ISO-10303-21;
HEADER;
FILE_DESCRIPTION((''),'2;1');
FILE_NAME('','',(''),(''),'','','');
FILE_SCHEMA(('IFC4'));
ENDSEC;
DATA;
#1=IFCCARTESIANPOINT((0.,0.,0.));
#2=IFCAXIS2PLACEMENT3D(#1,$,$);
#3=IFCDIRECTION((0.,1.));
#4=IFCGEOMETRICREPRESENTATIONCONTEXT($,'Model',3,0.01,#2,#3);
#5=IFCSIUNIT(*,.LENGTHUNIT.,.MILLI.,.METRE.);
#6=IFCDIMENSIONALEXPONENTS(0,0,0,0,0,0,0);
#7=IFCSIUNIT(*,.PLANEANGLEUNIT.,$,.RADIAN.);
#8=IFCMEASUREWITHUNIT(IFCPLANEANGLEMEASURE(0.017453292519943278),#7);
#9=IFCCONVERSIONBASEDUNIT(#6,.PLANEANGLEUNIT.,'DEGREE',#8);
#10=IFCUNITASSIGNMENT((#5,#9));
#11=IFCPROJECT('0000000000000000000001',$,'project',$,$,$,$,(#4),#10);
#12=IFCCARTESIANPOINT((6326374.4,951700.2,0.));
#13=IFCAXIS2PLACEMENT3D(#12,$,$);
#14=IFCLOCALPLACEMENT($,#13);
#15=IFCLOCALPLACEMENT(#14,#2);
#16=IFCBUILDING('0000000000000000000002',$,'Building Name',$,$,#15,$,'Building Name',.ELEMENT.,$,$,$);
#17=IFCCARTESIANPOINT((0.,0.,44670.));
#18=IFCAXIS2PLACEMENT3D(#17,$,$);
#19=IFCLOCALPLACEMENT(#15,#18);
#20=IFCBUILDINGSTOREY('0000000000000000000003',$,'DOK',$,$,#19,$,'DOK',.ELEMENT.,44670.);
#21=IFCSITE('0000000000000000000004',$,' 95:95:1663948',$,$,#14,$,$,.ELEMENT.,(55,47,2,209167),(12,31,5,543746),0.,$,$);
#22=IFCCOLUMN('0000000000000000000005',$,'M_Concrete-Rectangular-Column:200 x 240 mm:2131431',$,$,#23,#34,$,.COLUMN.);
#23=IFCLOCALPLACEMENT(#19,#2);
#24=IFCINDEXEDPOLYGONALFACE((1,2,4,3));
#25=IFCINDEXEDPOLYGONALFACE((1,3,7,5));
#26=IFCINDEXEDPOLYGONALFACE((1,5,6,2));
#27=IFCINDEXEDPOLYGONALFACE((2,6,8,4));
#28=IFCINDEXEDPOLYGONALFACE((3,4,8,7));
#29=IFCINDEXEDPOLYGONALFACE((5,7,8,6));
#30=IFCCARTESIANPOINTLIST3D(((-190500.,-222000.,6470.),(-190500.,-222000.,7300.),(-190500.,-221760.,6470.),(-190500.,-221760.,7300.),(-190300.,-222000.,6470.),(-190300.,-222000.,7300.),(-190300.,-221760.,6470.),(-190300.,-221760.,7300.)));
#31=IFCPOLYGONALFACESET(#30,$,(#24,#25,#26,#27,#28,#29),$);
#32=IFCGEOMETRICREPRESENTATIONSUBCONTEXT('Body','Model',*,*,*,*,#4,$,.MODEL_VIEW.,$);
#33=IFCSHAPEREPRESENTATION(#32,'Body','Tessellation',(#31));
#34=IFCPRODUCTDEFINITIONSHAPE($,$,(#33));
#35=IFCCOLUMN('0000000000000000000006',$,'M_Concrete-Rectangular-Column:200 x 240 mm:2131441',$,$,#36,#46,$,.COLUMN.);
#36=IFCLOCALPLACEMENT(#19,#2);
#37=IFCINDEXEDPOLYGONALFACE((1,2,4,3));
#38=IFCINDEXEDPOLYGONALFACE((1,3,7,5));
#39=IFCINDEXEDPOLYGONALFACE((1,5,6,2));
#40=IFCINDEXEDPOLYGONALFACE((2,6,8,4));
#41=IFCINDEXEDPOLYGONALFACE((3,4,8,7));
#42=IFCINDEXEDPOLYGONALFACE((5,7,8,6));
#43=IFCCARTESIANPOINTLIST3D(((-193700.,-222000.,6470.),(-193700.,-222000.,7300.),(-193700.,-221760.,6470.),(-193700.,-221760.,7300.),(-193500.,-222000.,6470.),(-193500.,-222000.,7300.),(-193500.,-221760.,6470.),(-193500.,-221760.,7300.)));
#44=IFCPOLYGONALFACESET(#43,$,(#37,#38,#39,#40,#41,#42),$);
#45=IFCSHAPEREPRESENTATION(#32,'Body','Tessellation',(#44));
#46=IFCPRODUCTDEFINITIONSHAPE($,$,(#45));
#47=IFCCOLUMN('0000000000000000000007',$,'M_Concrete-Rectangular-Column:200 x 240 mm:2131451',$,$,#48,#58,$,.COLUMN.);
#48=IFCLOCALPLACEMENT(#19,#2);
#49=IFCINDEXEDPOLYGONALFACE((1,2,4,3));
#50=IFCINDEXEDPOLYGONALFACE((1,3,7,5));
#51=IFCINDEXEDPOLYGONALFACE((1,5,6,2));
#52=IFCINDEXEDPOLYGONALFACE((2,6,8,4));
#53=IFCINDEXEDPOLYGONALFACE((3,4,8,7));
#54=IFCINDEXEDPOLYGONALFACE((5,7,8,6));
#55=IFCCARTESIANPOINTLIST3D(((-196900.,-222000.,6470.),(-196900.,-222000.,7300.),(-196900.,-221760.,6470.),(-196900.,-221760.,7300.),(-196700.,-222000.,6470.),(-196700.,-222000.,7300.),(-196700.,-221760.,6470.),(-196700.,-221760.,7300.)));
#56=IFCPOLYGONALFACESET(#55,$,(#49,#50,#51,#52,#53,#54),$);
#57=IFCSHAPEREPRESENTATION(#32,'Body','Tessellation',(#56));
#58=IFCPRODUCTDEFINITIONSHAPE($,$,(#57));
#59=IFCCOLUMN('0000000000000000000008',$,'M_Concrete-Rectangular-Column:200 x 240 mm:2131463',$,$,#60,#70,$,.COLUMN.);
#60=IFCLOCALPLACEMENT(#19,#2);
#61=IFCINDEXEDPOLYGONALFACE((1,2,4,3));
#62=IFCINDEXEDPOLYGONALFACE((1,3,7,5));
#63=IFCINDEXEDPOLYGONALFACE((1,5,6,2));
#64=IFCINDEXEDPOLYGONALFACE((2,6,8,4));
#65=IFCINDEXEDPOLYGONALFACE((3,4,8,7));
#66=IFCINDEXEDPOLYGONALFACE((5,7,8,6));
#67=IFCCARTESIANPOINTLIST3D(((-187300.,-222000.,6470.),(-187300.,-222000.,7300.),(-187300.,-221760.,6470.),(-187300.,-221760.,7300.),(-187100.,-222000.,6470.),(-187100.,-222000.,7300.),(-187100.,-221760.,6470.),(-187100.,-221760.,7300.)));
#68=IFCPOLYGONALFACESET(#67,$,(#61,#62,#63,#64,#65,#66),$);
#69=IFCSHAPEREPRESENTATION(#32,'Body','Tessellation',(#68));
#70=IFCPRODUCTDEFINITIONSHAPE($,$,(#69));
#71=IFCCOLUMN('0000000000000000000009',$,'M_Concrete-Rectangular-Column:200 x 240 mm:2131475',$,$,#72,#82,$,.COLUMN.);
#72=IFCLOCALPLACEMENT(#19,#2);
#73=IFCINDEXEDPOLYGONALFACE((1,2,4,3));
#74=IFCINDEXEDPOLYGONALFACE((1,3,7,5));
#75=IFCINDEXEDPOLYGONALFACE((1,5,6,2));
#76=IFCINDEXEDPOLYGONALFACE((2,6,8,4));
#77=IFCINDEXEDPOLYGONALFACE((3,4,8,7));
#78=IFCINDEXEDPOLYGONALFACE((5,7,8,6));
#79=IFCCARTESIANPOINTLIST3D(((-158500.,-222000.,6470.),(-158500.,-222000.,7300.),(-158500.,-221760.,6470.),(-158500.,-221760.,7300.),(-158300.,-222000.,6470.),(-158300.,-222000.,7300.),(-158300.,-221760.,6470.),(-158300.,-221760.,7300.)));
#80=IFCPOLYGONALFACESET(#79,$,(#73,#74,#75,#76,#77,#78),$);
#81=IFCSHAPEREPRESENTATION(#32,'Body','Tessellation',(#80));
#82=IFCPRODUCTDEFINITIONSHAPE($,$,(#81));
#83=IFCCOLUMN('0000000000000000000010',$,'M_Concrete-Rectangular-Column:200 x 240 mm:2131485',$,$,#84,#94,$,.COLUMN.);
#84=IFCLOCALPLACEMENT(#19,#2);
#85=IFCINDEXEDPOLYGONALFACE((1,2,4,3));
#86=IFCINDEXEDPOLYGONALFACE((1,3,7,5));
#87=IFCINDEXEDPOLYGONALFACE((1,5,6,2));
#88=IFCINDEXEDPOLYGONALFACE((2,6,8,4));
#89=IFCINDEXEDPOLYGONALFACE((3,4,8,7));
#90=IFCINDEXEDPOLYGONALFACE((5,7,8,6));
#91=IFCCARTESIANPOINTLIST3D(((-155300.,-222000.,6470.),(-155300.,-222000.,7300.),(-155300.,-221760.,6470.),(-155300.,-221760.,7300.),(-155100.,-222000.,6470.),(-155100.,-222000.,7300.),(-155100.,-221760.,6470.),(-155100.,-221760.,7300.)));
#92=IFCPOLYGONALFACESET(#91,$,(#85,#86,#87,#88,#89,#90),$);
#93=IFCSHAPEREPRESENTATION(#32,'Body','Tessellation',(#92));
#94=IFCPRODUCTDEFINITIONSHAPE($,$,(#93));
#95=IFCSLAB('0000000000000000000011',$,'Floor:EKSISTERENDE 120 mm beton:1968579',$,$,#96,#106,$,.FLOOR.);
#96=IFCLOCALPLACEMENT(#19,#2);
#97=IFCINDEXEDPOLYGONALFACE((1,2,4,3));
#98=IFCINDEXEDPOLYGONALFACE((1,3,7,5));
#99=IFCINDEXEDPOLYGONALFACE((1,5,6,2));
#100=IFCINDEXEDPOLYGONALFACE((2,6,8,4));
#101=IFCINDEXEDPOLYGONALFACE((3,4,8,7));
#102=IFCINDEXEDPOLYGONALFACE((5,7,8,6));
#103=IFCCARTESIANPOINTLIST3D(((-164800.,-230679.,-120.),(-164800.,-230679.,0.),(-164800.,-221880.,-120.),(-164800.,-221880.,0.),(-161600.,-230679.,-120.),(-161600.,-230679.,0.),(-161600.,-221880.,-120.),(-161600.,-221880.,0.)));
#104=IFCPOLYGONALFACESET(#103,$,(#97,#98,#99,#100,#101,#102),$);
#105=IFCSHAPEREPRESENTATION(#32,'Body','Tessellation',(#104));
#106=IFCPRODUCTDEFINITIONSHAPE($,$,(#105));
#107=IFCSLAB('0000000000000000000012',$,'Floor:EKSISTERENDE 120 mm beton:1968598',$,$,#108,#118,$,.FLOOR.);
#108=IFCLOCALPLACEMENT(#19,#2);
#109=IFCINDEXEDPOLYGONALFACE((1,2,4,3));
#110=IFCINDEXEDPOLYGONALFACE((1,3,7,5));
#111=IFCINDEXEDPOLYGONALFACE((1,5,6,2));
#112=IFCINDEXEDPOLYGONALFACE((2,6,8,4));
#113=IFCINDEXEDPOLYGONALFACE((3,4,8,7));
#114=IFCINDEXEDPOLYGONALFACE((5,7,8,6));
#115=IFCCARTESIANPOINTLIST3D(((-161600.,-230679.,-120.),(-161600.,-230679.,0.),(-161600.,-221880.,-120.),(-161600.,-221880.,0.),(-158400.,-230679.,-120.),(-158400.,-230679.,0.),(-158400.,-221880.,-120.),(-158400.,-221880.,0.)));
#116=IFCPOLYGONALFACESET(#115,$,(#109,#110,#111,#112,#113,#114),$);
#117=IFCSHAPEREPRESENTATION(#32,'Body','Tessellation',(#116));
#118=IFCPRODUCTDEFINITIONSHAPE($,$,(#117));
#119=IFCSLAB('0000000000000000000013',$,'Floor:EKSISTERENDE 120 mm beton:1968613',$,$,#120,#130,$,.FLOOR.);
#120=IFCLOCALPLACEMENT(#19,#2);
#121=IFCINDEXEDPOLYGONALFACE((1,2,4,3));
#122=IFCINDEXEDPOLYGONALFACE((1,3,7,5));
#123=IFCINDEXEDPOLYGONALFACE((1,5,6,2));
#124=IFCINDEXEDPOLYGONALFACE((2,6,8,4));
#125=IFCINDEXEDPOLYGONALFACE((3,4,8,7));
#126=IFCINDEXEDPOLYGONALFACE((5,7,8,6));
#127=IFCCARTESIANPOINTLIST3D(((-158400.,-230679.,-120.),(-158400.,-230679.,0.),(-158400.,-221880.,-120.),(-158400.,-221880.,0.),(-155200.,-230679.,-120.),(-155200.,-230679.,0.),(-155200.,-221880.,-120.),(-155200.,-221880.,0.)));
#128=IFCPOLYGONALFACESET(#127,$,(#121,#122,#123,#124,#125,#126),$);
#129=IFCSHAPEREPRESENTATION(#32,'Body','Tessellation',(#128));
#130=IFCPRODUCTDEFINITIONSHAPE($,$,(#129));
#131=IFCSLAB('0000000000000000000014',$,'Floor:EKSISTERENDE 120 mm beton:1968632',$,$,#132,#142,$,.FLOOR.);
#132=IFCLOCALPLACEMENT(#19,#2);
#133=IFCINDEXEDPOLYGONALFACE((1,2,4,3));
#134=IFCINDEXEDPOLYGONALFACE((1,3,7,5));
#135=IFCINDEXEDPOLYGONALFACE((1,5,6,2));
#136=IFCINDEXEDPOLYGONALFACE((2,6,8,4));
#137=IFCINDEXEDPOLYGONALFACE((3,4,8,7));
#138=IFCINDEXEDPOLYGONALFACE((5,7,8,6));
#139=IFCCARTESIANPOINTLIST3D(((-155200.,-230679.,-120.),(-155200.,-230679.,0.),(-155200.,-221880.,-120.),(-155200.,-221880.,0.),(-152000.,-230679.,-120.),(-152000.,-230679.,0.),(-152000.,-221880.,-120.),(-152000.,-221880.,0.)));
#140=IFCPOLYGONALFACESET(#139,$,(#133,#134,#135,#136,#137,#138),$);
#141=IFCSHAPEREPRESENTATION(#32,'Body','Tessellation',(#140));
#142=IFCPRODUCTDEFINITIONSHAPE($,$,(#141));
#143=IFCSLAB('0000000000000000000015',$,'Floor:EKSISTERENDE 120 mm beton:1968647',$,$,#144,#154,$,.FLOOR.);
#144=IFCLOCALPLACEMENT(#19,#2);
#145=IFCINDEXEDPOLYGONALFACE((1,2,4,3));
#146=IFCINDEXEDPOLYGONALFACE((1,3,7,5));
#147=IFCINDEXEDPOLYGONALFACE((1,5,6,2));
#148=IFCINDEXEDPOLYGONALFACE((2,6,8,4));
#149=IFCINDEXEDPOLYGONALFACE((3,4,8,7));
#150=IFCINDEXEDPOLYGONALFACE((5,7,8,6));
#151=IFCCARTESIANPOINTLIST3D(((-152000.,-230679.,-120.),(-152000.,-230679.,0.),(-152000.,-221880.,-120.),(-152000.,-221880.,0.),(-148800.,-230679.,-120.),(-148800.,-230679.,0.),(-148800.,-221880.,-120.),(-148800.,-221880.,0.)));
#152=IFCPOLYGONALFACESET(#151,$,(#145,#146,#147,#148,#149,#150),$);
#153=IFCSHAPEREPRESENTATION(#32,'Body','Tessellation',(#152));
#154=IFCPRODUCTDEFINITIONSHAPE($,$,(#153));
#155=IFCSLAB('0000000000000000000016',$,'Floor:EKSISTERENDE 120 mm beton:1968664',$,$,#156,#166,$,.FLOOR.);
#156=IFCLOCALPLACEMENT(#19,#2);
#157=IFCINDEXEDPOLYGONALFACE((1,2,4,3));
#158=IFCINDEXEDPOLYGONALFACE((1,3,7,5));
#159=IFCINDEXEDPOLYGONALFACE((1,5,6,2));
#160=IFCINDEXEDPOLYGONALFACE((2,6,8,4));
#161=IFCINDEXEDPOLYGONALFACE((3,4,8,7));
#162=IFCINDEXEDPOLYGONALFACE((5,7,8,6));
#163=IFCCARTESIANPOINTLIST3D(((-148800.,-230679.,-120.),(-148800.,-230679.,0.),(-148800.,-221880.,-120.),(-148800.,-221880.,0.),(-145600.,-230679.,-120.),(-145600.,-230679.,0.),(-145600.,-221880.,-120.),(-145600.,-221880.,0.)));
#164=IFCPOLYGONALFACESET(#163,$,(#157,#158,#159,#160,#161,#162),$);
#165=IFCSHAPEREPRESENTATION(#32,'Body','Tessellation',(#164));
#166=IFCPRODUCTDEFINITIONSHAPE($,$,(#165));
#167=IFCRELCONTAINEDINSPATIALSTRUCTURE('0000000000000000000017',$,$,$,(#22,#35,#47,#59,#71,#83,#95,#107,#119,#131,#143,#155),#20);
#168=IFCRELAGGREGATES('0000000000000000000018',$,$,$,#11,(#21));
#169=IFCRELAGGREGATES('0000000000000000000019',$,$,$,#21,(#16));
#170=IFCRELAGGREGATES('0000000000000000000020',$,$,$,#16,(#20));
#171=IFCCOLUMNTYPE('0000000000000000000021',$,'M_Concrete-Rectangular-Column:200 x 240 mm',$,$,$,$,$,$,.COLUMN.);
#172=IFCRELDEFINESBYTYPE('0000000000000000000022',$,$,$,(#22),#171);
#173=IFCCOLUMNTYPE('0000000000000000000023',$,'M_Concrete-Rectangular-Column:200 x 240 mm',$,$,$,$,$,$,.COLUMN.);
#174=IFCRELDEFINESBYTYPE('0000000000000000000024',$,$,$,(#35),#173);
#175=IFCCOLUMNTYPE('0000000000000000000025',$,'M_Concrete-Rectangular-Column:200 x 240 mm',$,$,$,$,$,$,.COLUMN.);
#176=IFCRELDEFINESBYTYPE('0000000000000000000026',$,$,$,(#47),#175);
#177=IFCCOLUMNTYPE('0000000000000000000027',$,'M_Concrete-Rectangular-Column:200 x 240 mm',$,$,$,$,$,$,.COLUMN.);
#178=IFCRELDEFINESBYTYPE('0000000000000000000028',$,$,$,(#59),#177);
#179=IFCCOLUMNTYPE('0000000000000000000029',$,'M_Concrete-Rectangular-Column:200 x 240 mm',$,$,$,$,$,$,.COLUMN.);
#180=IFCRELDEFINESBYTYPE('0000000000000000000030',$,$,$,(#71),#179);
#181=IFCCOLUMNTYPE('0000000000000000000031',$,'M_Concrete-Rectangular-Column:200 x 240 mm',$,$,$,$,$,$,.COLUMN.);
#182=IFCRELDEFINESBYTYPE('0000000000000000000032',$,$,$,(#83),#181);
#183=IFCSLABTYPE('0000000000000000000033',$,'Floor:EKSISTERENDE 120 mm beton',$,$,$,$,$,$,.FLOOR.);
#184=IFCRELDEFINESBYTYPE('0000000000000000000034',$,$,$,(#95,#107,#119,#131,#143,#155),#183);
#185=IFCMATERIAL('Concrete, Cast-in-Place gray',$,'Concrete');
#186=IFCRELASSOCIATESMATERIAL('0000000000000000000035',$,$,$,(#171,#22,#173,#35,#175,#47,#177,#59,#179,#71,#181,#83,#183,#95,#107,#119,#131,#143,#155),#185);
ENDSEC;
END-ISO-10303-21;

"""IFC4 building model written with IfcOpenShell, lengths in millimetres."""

from ifc_helpers import new_model, entity, si_unit, converted_unit, direction, frame, origin, place, context, subcontext, project, spatial, indexed_curve, outline, extrude, source, transform, mapped, material, type_object, type_shapes, element, save


model = new_model("IFC4")

# Units and contexts
model_context = context("Model", 3, precision=0.01, world=origin(), true_north=direction((0.0, 1.0)))
body_context = subcontext(model_context, "Body", "Model", "MODEL_VIEW")
ifc_project = project(units=[si_unit("LENGTHUNIT", "METRE", prefix="MILLI"), converted_unit("PLANEANGLEUNIT", "DEGREE", entity("IfcPlaneAngleMeasure", 0.017453292519943278), si_unit("PLANEANGLEUNIT", "RADIAN"), dimensions=[0, 0, 0, 0, 0, 0, 0])], contexts=[model_context])

# Site, building, storey
site_placement = place(None, frame((6326374.4, 951700.2, 0.0)))
site = spatial("IfcSite", under=ifc_project, at=site_placement, Name=" 95:95:1663948", CompositionType="ELEMENT", RefLatitude=(55, 47, 2, 209167), RefLongitude=(12, 31, 5, 543746), RefElevation=0.0)
building_placement = place(site_placement, origin())
building = spatial("IfcBuilding", under=site, at=building_placement, Name="Building Name", LongName="Building Name", CompositionType="ELEMENT")
storey_placement = place(building_placement, frame((0.0, 0.0, 44670.0)))
storey = spatial("IfcBuildingStorey", under=building, at=storey_placement, Name="DOK", LongName="DOK", CompositionType="ELEMENT", Elevation=44670.0)

# Columns
ifc_material = material(Name="Concrete, Cast-in-Place gray", Category="Concrete")
column_type_1 = type_object("IfcColumnType", Name="M_Concrete-Rectangular-Column:200 x 240 mm", PredefinedType="COLUMN", material=ifc_material)
shared_shape_1 = source(origin(), body_context, "Body", "SweptSolid", [
    extrude(outline(indexed_curve([(-100.0, -120.0), (100.0, -120.0), (100.0, 120.0), (-100.0, 120.0), (-100.0, -120.0)], self_intersect=False)), frame((-190400.0, -221880.0, 51140.0), z_axis=(0.0, 0.0, 1.0), x_axis=(-1.0, 0.0, 0.0)), (0.0, 0.0, 1.0), 830.0),
])
type_shapes(column_type_1, [shared_shape_1])
column_1_placement = place(storey_placement, frame((0.0, 0.0, -44670.0)))
element("IfcColumn", 1, at=column_1_placement, inside=storey, type_object=column_type_1, material=ifc_material, Name="M_Concrete-Rectangular-Column:200 x 240 mm:2131431", PredefinedType="COLUMN", context=body_context, shape_type="MappedRepresentation", body=[
    mapped(shared_shape_1, transform((0.0, 0.0, 0.0), scale=1.0)),
])
column_type_2 = type_object("IfcColumnType", Name="M_Concrete-Rectangular-Column:200 x 240 mm", PredefinedType="COLUMN", material=ifc_material)
shared_shape_2 = source(origin(), body_context, "Body", "SweptSolid", [
    extrude(outline(indexed_curve([(-100.0, -120.0), (100.0, -120.0), (100.0, 120.0), (-100.0, 120.0), (-100.0, -120.0)], self_intersect=False)), frame((-193600.0, -221880.0, 51140.0), z_axis=(0.0, 0.0, 1.0), x_axis=(-1.0, 0.0, 0.0)), (0.0, 0.0, 1.0), 830.0),
])
type_shapes(column_type_2, [shared_shape_2])
column_2_placement = place(storey_placement, frame((0.0, 0.0, -44670.0)))
element("IfcColumn", 2, at=column_2_placement, inside=storey, type_object=column_type_2, material=ifc_material, Name="M_Concrete-Rectangular-Column:200 x 240 mm:2131441", PredefinedType="COLUMN", context=body_context, shape_type="MappedRepresentation", body=[
    mapped(shared_shape_2, transform((0.0, 0.0, 0.0), scale=1.0)),
])
column_type_3 = type_object("IfcColumnType", Name="M_Concrete-Rectangular-Column:200 x 240 mm", PredefinedType="COLUMN", material=ifc_material)
shared_shape_3 = source(origin(), body_context, "Body", "SweptSolid", [
    extrude(outline(indexed_curve([(-100.0, -120.0), (100.0, -120.0), (100.0, 120.0), (-100.0, 120.0), (-100.0, -120.0)], self_intersect=False)), frame((-196800.0, -221880.0, 51140.0), z_axis=(0.0, 0.0, 1.0), x_axis=(-1.0, 0.0, 0.0)), (0.0, 0.0, 1.0), 830.0),
])
type_shapes(column_type_3, [shared_shape_3])
column_3_placement = place(storey_placement, frame((0.0, 0.0, -44670.0)))
element("IfcColumn", 3, at=column_3_placement, inside=storey, type_object=column_type_3, material=ifc_material, Name="M_Concrete-Rectangular-Column:200 x 240 mm:2131451", PredefinedType="COLUMN", context=body_context, shape_type="MappedRepresentation", body=[
    mapped(shared_shape_3, transform((0.0, 0.0, 0.0), scale=1.0)),
])
column_type_4 = type_object("IfcColumnType", Name="M_Concrete-Rectangular-Column:200 x 240 mm", PredefinedType="COLUMN", material=ifc_material)
shared_shape_4 = source(origin(), body_context, "Body", "SweptSolid", [
    extrude(outline(indexed_curve([(-100.0, -120.0), (100.0, -120.0), (100.0, 120.0), (-100.0, 120.0), (-100.0, -120.0)], self_intersect=False)), frame((-187200.0, -221880.0, 51140.0), z_axis=(0.0, 0.0, 1.0), x_axis=(-1.0, 0.0, 0.0)), (0.0, 0.0, 1.0), 830.0),
])
type_shapes(column_type_4, [shared_shape_4])
column_4_placement = place(storey_placement, frame((0.0, 0.0, -44670.0)))
element("IfcColumn", 4, at=column_4_placement, inside=storey, type_object=column_type_4, material=ifc_material, Name="M_Concrete-Rectangular-Column:200 x 240 mm:2131463", PredefinedType="COLUMN", context=body_context, shape_type="MappedRepresentation", body=[
    mapped(shared_shape_4, transform((0.0, 0.0, 0.0), scale=1.0)),
])
column_type_5 = type_object("IfcColumnType", Name="M_Concrete-Rectangular-Column:200 x 240 mm", PredefinedType="COLUMN", material=ifc_material)
shared_shape_5 = source(origin(), body_context, "Body", "SweptSolid", [
    extrude(outline(indexed_curve([(-100.0, -120.0), (100.0, -120.0), (100.0, 120.0), (-100.0, 120.0), (-100.0, -120.0)], self_intersect=False)), frame((-158400.0, -221880.0, 51140.0), z_axis=(0.0, 0.0, 1.0), x_axis=(-1.0, 0.0, 0.0)), (0.0, 0.0, 1.0), 830.0),
])
type_shapes(column_type_5, [shared_shape_5])
column_5_placement = place(storey_placement, frame((0.0, 0.0, -44670.0)))
element("IfcColumn", 5, at=column_5_placement, inside=storey, type_object=column_type_5, material=ifc_material, Name="M_Concrete-Rectangular-Column:200 x 240 mm:2131475", PredefinedType="COLUMN", context=body_context, shape_type="MappedRepresentation", body=[
    mapped(shared_shape_5, transform((0.0, 0.0, 0.0), scale=1.0)),
])
column_type_6 = type_object("IfcColumnType", Name="M_Concrete-Rectangular-Column:200 x 240 mm", PredefinedType="COLUMN", material=ifc_material)
shared_shape_6 = source(origin(), body_context, "Body", "SweptSolid", [
    extrude(outline(indexed_curve([(-100.0, -120.0), (100.0, -120.0), (100.0, 120.0), (-100.0, 120.0), (-100.0, -120.0)], self_intersect=False)), frame((-155200.0, -221880.0, 51140.0), z_axis=(0.0, 0.0, 1.0), x_axis=(-1.0, 0.0, 0.0)), (0.0, 0.0, 1.0), 830.0),
])
type_shapes(column_type_6, [shared_shape_6])
column_6_placement = place(storey_placement, frame((0.0, 0.0, -44670.0)))
element("IfcColumn", 6, at=column_6_placement, inside=storey, type_object=column_type_6, material=ifc_material, Name="M_Concrete-Rectangular-Column:200 x 240 mm:2131485", PredefinedType="COLUMN", context=body_context, shape_type="MappedRepresentation", body=[
    mapped(shared_shape_6, transform((0.0, 0.0, 0.0), scale=1.0)),
])

# Slabs
slab_type_1 = type_object("IfcSlabType", Name="Floor:EKSISTERENDE 120 mm beton", PredefinedType="FLOOR", material=ifc_material)
slab_1_placement = place(storey_placement, origin())
element("IfcSlab", 7, at=slab_1_placement, inside=storey, type_object=slab_type_1, material=ifc_material, Name="Floor:EKSISTERENDE 120 mm beton:1968579", PredefinedType="FLOOR", context=body_context, shape_type="SweptSolid", body=[
    extrude(outline(indexed_curve([(-4399.5, -1600.0), (4399.5, -1600.0), (4399.5, 1600.0), (-4399.5, 1600.0), (-4399.5, -1600.0)], self_intersect=False)), frame((-163200.0, -226279.5, 0.0), z_axis=(0.0, 0.0, -1.0), x_axis=(0.0, 1.0, 0.0)), (0.0, 0.0, 1.0), 120.0),
])
slab_2_placement = place(storey_placement, origin())
element("IfcSlab", 8, at=slab_2_placement, inside=storey, type_object=slab_type_1, material=ifc_material, Name="Floor:EKSISTERENDE 120 mm beton:1968598", PredefinedType="FLOOR", context=body_context, shape_type="SweptSolid", body=[
    extrude(outline(indexed_curve([(-4399.5, -1600.0), (4399.5, -1600.0), (4399.5, 1600.0), (-4399.5, 1600.0), (-4399.5, -1600.0)], self_intersect=False)), frame((-160000.0, -226279.5, 0.0), z_axis=(0.0, 0.0, -1.0), x_axis=(0.0, 1.0, 0.0)), (0.0, 0.0, 1.0), 120.0),
])
slab_3_placement = place(storey_placement, origin())
element("IfcSlab", 9, at=slab_3_placement, inside=storey, type_object=slab_type_1, material=ifc_material, Name="Floor:EKSISTERENDE 120 mm beton:1968613", PredefinedType="FLOOR", context=body_context, shape_type="SweptSolid", body=[
    extrude(outline(indexed_curve([(-4399.5, -1600.0), (4399.5, -1600.0), (4399.5, 1600.0), (-4399.5, 1600.0), (-4399.5, -1600.0)], self_intersect=False)), frame((-156800.0, -226279.5, 0.0), z_axis=(0.0, 0.0, -1.0), x_axis=(0.0, 1.0, 0.0)), (0.0, 0.0, 1.0), 120.0),
])
slab_4_placement = place(storey_placement, origin())
element("IfcSlab", 10, at=slab_4_placement, inside=storey, type_object=slab_type_1, material=ifc_material, Name="Floor:EKSISTERENDE 120 mm beton:1968632", PredefinedType="FLOOR", context=body_context, shape_type="SweptSolid", body=[
    extrude(outline(indexed_curve([(-4399.5, -1600.0), (4399.5, -1600.0), (4399.5, 1600.0), (-4399.5, 1600.0), (-4399.5, -1600.0)], self_intersect=False)), frame((-153600.0, -226279.5, 0.0), z_axis=(0.0, 0.0, -1.0), x_axis=(0.0, 1.0, 0.0)), (0.0, 0.0, 1.0), 120.0),
])
slab_5_placement = place(storey_placement, origin())
element("IfcSlab", 11, at=slab_5_placement, inside=storey, type_object=slab_type_1, material=ifc_material, Name="Floor:EKSISTERENDE 120 mm beton:1968647", PredefinedType="FLOOR", context=body_context, shape_type="SweptSolid", body=[
    extrude(outline(indexed_curve([(-4399.5, -1600.0), (4399.5, -1600.0), (4399.5, 1600.0), (-4399.5, 1600.0), (-4399.5, -1600.0)], self_intersect=False)), frame((-150400.0, -226279.5, 0.0), z_axis=(0.0, 0.0, -1.0), x_axis=(0.0, 1.0, 0.0)), (0.0, 0.0, 1.0), 120.0),
])
slab_6_placement = place(storey_placement, origin())
element("IfcSlab", 12, at=slab_6_placement, inside=storey, type_object=slab_type_1, material=ifc_material, Name="Floor:EKSISTERENDE 120 mm beton:1968664", PredefinedType="FLOOR", context=body_context, shape_type="SweptSolid", body=[
    extrude(outline(indexed_curve([(-4399.5, -1600.0), (4399.5, -1600.0), (4399.5, 1600.0), (-4399.5, 1600.0), (-4399.5, -1600.0)], self_intersect=False)), frame((-147200.0, -226279.5, 0.0), z_axis=(0.0, 0.0, -1.0), x_axis=(0.0, 1.0, 0.0)), (0.0, 0.0, 1.0), 120.0),
])

save(model, "model.ifc")
